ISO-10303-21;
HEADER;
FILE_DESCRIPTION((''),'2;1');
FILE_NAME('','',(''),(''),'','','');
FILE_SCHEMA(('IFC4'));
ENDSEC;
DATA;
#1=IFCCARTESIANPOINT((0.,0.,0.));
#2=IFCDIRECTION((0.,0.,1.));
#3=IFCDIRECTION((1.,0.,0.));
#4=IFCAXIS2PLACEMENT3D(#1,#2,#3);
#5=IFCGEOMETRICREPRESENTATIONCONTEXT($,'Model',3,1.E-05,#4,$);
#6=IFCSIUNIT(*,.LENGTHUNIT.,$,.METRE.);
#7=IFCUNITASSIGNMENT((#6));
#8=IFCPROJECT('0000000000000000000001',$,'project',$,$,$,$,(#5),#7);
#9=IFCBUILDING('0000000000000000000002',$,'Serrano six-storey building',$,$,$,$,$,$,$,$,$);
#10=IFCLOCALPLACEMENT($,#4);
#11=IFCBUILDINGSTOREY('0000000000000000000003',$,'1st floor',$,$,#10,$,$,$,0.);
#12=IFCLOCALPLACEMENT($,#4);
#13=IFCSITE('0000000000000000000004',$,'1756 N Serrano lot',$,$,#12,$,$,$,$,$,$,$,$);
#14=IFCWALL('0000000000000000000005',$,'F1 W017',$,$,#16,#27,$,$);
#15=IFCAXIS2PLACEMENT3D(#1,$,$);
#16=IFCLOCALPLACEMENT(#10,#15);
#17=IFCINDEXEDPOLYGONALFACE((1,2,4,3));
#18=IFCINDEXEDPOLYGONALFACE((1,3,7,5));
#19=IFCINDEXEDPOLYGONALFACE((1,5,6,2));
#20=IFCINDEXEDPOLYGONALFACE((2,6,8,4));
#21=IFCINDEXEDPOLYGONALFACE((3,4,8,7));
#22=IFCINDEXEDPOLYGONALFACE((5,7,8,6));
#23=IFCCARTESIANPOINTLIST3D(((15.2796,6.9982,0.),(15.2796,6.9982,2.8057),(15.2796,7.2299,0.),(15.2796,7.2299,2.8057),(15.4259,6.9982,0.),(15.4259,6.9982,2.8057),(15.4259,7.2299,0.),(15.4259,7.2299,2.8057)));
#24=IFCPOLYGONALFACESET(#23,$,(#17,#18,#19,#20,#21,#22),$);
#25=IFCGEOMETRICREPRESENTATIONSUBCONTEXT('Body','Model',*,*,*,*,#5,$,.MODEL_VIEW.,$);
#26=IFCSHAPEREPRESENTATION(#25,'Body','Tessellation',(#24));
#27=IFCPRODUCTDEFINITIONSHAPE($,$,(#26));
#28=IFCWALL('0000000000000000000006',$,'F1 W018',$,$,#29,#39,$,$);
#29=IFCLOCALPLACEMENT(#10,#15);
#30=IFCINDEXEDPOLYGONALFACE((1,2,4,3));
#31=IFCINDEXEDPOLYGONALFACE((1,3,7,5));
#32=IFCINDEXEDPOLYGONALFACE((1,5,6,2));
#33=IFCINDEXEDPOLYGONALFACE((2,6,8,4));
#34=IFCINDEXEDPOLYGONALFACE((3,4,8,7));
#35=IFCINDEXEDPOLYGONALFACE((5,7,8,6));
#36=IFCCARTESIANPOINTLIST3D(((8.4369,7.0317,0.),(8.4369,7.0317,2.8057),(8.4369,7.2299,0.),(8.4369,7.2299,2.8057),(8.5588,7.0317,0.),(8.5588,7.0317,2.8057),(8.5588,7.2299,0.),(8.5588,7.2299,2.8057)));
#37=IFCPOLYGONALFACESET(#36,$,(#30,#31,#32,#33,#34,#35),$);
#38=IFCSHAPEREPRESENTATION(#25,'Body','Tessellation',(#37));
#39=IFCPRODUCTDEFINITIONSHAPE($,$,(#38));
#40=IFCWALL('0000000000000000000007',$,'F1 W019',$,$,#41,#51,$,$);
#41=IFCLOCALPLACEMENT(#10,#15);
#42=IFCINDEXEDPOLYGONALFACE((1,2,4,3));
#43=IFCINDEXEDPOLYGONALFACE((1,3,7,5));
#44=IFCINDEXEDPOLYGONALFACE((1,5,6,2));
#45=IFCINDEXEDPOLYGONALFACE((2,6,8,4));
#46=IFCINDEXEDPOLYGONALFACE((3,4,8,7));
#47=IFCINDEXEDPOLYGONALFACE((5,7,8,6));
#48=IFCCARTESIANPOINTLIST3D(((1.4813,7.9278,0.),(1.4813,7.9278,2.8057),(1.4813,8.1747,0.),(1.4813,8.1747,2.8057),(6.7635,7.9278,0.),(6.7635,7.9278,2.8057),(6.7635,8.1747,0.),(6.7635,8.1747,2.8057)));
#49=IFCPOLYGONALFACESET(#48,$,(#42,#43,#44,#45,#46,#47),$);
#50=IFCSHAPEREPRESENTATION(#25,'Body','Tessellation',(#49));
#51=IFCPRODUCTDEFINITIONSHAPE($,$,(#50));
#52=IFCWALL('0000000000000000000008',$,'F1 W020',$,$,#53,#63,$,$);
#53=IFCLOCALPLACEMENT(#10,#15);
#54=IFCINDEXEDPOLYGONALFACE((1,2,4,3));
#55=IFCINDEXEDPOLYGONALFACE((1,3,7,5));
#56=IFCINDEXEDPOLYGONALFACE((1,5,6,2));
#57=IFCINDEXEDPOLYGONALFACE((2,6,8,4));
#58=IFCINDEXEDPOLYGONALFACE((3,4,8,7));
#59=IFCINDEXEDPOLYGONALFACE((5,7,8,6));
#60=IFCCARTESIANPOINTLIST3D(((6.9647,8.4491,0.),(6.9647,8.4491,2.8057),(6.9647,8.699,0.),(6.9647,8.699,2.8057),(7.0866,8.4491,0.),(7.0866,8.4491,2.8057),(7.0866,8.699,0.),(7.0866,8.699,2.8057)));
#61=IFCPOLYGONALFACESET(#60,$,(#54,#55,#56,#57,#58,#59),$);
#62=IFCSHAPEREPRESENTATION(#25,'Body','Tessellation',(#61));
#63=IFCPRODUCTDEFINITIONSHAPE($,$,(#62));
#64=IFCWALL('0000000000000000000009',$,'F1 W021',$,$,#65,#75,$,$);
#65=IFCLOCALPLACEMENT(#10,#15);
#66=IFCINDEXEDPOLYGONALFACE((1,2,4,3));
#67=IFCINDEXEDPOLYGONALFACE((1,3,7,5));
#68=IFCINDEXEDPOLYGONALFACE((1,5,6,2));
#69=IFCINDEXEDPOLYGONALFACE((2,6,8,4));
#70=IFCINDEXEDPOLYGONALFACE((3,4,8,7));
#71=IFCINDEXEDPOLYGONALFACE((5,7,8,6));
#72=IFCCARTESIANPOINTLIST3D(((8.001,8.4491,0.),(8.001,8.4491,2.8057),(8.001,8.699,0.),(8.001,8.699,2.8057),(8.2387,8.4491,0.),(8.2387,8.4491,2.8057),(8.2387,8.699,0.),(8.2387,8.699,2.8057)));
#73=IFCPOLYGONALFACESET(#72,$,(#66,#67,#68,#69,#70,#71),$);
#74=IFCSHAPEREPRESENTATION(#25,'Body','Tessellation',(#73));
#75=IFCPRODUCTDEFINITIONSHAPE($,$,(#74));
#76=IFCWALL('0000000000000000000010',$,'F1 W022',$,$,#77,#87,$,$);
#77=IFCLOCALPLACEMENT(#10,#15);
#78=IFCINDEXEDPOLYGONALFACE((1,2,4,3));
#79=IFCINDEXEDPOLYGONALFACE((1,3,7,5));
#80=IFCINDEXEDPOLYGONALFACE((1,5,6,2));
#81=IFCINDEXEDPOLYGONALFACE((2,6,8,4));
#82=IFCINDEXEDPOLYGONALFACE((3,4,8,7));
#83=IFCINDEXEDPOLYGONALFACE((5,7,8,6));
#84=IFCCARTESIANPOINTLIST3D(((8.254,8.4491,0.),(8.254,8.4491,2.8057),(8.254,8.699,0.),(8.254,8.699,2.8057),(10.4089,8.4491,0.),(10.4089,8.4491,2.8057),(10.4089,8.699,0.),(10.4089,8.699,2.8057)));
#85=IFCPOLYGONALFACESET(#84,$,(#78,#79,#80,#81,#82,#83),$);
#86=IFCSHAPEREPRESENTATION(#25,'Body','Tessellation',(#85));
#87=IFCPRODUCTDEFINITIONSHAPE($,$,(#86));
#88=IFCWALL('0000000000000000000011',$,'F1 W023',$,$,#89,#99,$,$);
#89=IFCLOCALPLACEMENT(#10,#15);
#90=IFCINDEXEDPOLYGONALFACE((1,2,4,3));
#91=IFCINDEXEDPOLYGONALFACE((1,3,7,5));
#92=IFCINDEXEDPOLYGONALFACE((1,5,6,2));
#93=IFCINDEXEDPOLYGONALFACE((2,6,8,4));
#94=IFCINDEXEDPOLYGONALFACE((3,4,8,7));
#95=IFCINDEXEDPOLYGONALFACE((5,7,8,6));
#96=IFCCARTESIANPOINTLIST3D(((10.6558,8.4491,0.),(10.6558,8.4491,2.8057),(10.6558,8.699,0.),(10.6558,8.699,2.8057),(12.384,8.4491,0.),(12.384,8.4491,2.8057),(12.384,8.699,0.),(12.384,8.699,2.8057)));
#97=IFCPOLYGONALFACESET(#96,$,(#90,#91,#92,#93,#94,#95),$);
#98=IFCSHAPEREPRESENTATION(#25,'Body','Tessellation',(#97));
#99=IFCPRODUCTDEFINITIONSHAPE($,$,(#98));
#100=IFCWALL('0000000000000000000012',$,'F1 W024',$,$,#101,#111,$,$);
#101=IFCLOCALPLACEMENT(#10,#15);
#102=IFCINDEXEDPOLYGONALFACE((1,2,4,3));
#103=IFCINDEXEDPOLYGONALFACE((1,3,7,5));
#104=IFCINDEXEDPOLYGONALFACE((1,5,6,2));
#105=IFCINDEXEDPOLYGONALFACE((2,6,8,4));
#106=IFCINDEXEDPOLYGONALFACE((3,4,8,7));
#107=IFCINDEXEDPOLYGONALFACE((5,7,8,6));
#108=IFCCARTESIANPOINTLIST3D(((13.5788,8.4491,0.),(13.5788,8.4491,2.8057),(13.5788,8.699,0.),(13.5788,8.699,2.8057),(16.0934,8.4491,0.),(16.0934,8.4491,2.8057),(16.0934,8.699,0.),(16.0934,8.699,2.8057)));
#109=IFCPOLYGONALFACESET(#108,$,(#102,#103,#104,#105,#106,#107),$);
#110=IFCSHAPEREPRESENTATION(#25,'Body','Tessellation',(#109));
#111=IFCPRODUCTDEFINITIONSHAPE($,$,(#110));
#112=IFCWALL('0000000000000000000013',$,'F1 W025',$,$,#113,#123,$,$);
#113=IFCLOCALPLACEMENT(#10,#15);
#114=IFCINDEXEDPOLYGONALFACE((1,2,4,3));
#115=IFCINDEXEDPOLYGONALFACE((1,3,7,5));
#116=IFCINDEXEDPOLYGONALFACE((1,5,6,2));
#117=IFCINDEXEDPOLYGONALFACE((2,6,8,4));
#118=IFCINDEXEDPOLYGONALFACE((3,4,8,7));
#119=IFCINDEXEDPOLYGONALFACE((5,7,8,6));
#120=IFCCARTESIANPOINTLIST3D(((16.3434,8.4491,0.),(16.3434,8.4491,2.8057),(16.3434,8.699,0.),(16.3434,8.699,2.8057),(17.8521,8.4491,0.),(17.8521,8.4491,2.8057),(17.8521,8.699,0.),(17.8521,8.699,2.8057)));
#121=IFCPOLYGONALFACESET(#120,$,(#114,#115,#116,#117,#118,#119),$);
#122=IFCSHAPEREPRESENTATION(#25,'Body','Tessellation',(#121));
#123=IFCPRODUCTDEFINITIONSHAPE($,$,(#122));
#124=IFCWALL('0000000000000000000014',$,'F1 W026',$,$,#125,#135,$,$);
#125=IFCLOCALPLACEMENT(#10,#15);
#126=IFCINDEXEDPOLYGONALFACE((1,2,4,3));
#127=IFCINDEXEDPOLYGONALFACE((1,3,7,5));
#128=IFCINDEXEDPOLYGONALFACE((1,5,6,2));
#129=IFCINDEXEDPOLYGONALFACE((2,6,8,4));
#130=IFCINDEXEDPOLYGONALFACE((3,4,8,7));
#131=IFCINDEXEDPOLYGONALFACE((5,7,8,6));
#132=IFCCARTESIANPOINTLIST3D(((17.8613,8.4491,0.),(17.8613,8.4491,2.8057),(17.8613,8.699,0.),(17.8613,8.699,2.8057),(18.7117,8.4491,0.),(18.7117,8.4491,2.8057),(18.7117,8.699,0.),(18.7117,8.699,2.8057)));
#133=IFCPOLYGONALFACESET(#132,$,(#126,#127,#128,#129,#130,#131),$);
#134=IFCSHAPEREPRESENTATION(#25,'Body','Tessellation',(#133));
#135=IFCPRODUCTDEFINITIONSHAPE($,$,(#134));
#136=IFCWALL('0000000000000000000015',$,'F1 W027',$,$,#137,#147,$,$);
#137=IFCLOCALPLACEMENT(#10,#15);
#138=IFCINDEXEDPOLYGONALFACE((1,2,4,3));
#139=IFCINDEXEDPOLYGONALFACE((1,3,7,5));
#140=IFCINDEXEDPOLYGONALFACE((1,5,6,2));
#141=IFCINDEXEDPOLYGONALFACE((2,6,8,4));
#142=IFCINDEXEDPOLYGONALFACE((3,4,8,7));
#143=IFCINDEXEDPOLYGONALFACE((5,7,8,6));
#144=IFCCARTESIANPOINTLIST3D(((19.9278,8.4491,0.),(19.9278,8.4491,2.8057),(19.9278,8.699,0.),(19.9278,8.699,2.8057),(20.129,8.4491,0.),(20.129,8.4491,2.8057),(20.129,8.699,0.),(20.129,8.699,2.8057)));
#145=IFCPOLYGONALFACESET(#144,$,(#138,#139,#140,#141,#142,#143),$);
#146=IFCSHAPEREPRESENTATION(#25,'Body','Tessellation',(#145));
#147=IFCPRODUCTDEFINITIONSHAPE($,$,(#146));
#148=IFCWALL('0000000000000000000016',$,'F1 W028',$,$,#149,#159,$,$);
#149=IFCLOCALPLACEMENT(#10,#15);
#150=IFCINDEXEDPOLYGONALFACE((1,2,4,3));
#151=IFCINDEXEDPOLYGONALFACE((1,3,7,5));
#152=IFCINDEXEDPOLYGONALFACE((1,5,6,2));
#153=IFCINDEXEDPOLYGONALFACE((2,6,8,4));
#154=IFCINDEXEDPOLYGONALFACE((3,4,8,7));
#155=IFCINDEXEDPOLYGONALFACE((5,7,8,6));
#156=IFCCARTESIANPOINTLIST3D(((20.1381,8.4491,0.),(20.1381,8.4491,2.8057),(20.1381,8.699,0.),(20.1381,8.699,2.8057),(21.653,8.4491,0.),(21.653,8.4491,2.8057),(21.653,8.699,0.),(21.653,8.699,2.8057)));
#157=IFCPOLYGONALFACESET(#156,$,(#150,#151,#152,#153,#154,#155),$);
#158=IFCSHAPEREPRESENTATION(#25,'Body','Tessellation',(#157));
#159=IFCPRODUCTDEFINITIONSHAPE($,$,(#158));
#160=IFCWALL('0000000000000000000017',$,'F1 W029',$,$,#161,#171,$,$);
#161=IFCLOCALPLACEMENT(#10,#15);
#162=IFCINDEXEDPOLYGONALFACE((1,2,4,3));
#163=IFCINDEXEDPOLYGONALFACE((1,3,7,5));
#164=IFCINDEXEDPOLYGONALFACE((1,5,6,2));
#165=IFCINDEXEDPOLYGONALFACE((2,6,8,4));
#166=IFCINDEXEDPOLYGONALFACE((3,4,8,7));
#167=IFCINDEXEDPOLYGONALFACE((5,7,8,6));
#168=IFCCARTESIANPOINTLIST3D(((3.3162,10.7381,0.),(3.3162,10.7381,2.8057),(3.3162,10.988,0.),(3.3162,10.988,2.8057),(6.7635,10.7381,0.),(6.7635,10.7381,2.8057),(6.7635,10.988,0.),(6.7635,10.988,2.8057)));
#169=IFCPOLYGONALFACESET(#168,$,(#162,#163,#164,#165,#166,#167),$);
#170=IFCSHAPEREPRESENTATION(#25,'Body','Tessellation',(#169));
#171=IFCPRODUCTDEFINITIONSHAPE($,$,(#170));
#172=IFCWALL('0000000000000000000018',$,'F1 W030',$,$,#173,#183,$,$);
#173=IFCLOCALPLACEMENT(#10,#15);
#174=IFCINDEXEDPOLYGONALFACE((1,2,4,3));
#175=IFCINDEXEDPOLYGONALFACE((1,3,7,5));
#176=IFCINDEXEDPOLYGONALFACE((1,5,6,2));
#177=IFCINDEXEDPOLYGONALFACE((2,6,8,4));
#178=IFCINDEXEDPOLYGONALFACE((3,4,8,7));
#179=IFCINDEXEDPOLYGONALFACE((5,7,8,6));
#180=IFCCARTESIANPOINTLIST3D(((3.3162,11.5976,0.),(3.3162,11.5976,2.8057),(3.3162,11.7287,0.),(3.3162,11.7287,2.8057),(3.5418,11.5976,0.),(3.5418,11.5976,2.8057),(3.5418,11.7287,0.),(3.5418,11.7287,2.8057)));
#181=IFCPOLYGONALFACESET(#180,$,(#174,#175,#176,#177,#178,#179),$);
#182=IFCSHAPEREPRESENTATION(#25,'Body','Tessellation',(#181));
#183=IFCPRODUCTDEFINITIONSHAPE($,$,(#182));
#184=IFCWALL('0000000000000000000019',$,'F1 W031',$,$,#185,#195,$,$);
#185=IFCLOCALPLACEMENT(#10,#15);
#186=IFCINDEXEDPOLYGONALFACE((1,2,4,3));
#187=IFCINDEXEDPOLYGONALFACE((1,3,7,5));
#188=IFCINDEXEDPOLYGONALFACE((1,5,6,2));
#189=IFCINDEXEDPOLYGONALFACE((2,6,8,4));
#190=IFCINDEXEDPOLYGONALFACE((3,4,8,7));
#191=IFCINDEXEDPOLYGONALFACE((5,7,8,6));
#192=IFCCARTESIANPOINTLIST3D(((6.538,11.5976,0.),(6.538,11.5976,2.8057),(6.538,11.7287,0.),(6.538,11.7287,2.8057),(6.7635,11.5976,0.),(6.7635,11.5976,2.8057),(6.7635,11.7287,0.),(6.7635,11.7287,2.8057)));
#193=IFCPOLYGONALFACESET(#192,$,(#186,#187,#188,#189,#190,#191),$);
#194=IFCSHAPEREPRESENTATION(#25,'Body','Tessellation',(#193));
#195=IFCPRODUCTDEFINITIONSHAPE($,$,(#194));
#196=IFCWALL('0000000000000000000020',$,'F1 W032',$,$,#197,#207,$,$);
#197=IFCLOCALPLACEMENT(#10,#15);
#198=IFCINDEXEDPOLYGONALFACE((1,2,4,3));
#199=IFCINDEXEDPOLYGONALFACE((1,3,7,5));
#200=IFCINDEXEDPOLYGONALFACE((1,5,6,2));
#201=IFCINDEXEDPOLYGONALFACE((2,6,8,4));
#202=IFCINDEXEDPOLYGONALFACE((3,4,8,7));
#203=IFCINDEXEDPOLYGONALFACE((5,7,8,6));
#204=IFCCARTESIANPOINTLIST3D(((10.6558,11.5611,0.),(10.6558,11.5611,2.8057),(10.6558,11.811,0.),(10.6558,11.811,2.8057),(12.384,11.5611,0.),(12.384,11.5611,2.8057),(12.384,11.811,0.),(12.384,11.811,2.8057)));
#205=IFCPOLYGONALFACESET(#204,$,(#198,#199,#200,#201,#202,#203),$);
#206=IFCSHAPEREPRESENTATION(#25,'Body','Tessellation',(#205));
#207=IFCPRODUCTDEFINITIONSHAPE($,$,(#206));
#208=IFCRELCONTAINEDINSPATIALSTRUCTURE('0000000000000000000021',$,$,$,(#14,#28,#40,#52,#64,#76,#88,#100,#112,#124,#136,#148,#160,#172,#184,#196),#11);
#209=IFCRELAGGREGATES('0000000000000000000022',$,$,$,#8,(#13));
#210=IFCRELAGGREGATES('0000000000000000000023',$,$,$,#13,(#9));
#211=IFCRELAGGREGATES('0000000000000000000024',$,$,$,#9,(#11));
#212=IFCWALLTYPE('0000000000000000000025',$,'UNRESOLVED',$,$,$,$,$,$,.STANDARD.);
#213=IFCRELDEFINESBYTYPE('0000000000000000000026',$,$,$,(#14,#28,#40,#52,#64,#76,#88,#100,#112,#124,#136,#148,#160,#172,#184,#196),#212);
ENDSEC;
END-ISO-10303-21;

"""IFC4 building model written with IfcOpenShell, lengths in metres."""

from ifc_helpers import new_model, si_unit, origin, origin_with_axes, place, context, subcontext, project, spatial, polyline, outline, extrude, type_object, element, save


model = new_model("IFC4")

# Units and contexts
model_context = context("Model", 3, precision=1e-05, world=origin_with_axes())
body_context = subcontext(model_context, "Body", "Model", "MODEL_VIEW")
ifc_project = project(units=[si_unit("LENGTHUNIT", "METRE")], contexts=[model_context])

# Site, building, storey
site_placement = place(None, origin_with_axes())
site = spatial("IfcSite", under=ifc_project, at=site_placement, Name="1756 N Serrano lot")
building = spatial("IfcBuilding", under=site, Name="Serrano six-storey building")
storey_placement = place(None, origin_with_axes())
storey = spatial("IfcBuildingStorey", under=building, at=storey_placement, Name="1st floor", Elevation=0.0)

# Walls
wall_type = type_object("IfcWallType", Name="UNRESOLVED", PredefinedType="STANDARD")
wall_1_placement = place(storey_placement, origin_with_axes())
element("IfcWall", 1, at=wall_1_placement, inside=storey, type_object=wall_type, Name="F1 W017", context=body_context, shape_type="SweptSolid", body=[
    extrude(outline(polyline([(15.4259, 7.2299), (15.4259, 6.9982), (15.2796, 6.9982), (15.2796, 7.2299), (15.4259, 7.2299)])), origin(), (0.0, 0.0, 1.0), 2.8057),
])
wall_2_placement = place(storey_placement, origin_with_axes())
element("IfcWall", 2, at=wall_2_placement, inside=storey, type_object=wall_type, Name="F1 W018", context=body_context, shape_type="SweptSolid", body=[
    extrude(outline(polyline([(8.5588, 7.2299), (8.5588, 7.0317), (8.4369, 7.0317), (8.4369, 7.2299), (8.5588, 7.2299)])), origin(), (0.0, 0.0, 1.0), 2.8057),
])
wall_3_placement = place(storey_placement, origin_with_axes())
element("IfcWall", 3, at=wall_3_placement, inside=storey, type_object=wall_type, Name="F1 W019", context=body_context, shape_type="SweptSolid", body=[
    extrude(outline(polyline([(6.7635, 8.1747), (6.7635, 7.9278), (1.4813, 7.9278), (1.4813, 8.1747), (6.7635, 8.1747)])), origin(), (0.0, 0.0, 1.0), 2.8057),
])
wall_4_placement = place(storey_placement, origin_with_axes())
element("IfcWall", 4, at=wall_4_placement, inside=storey, type_object=wall_type, Name="F1 W020", context=body_context, shape_type="SweptSolid", body=[
    extrude(outline(polyline([(7.0866, 8.699), (7.0866, 8.4491), (6.9647, 8.4491), (6.9647, 8.699), (7.0866, 8.699)])), origin(), (0.0, 0.0, 1.0), 2.8057),
])
wall_5_placement = place(storey_placement, origin_with_axes())
element("IfcWall", 5, at=wall_5_placement, inside=storey, type_object=wall_type, Name="F1 W021", context=body_context, shape_type="SweptSolid", body=[
    extrude(outline(polyline([(8.2387, 8.699), (8.2387, 8.4491), (8.001, 8.4491), (8.001, 8.699), (8.2387, 8.699)])), origin(), (0.0, 0.0, 1.0), 2.8057),
])
wall_6_placement = place(storey_placement, origin_with_axes())
element("IfcWall", 6, at=wall_6_placement, inside=storey, type_object=wall_type, Name="F1 W022", context=body_context, shape_type="SweptSolid", body=[
    extrude(outline(polyline([(10.4089, 8.699), (10.4089, 8.4491), (8.254, 8.4491), (8.254, 8.699), (10.4089, 8.699)])), origin(), (0.0, 0.0, 1.0), 2.8057),
])
wall_7_placement = place(storey_placement, origin_with_axes())
element("IfcWall", 7, at=wall_7_placement, inside=storey, type_object=wall_type, Name="F1 W023", context=body_context, shape_type="SweptSolid", body=[
    extrude(outline(polyline([(12.384, 8.699), (12.384, 8.4491), (10.6558, 8.4491), (10.6558, 8.699), (12.384, 8.699)])), origin(), (0.0, 0.0, 1.0), 2.8057),
])
wall_8_placement = place(storey_placement, origin_with_axes())
element("IfcWall", 8, at=wall_8_placement, inside=storey, type_object=wall_type, Name="F1 W024", context=body_context, shape_type="SweptSolid", body=[
    extrude(outline(polyline([(16.0934, 8.699), (16.0934, 8.4491), (13.5788, 8.4491), (13.5788, 8.699), (16.0934, 8.699)])), origin(), (0.0, 0.0, 1.0), 2.8057),
])
wall_9_placement = place(storey_placement, origin_with_axes())
element("IfcWall", 9, at=wall_9_placement, inside=storey, type_object=wall_type, Name="F1 W025", context=body_context, shape_type="SweptSolid", body=[
    extrude(outline(polyline([(17.8521, 8.699), (17.8521, 8.4491), (16.3434, 8.4491), (16.3434, 8.699), (17.8521, 8.699)])), origin(), (0.0, 0.0, 1.0), 2.8057),
])
wall_10_placement = place(storey_placement, origin_with_axes())
element("IfcWall", 10, at=wall_10_placement, inside=storey, type_object=wall_type, Name="F1 W026", context=body_context, shape_type="SweptSolid", body=[
    extrude(outline(polyline([(18.7117, 8.699), (18.7117, 8.4491), (17.8613, 8.4491), (17.8613, 8.699), (18.7117, 8.699)])), origin(), (0.0, 0.0, 1.0), 2.8057),
])
wall_11_placement = place(storey_placement, origin_with_axes())
element("IfcWall", 11, at=wall_11_placement, inside=storey, type_object=wall_type, Name="F1 W027", context=body_context, shape_type="SweptSolid", body=[
    extrude(outline(polyline([(20.129, 8.699), (20.129, 8.4491), (19.9278, 8.4491), (19.9278, 8.699), (20.129, 8.699)])), origin(), (0.0, 0.0, 1.0), 2.8057),
])
wall_12_placement = place(storey_placement, origin_with_axes())
element("IfcWall", 12, at=wall_12_placement, inside=storey, type_object=wall_type, Name="F1 W028", context=body_context, shape_type="SweptSolid", body=[
    extrude(outline(polyline([(21.653, 8.699), (21.653, 8.4491), (20.1381, 8.4491), (20.1381, 8.699), (21.653, 8.699)])), origin(), (0.0, 0.0, 1.0), 2.8057),
])
wall_13_placement = place(storey_placement, origin_with_axes())
element("IfcWall", 13, at=wall_13_placement, inside=storey, type_object=wall_type, Name="F1 W029", context=body_context, shape_type="SweptSolid", body=[
    extrude(outline(polyline([(6.7635, 10.988), (6.7635, 10.7381), (3.3162, 10.7381), (3.3162, 10.988), (6.7635, 10.988)])), origin(), (0.0, 0.0, 1.0), 2.8057),
])
wall_14_placement = place(storey_placement, origin_with_axes())
element("IfcWall", 14, at=wall_14_placement, inside=storey, type_object=wall_type, Name="F1 W030", context=body_context, shape_type="SweptSolid", body=[
    extrude(outline(polyline([(3.5418, 11.7287), (3.5418, 11.5976), (3.3162, 11.5976), (3.3162, 11.7287), (3.5418, 11.7287)])), origin(), (0.0, 0.0, 1.0), 2.8057),
])
wall_15_placement = place(storey_placement, origin_with_axes())
element("IfcWall", 15, at=wall_15_placement, inside=storey, type_object=wall_type, Name="F1 W031", context=body_context, shape_type="SweptSolid", body=[
    extrude(outline(polyline([(6.7635, 11.7287), (6.7635, 11.5976), (6.538, 11.5976), (6.538, 11.7287), (6.7635, 11.7287)])), origin(), (0.0, 0.0, 1.0), 2.8057),
])
wall_16_placement = place(storey_placement, origin_with_axes())
element("IfcWall", 16, at=wall_16_placement, inside=storey, type_object=wall_type, Name="F1 W032", context=body_context, shape_type="SweptSolid", body=[
    extrude(outline(polyline([(12.384, 11.811), (12.384, 11.5611), (10.6558, 11.5611), (10.6558, 11.811), (12.384, 11.811)])), origin(), (0.0, 0.0, 1.0), 2.8057),
])

save(model, "model.ifc")
